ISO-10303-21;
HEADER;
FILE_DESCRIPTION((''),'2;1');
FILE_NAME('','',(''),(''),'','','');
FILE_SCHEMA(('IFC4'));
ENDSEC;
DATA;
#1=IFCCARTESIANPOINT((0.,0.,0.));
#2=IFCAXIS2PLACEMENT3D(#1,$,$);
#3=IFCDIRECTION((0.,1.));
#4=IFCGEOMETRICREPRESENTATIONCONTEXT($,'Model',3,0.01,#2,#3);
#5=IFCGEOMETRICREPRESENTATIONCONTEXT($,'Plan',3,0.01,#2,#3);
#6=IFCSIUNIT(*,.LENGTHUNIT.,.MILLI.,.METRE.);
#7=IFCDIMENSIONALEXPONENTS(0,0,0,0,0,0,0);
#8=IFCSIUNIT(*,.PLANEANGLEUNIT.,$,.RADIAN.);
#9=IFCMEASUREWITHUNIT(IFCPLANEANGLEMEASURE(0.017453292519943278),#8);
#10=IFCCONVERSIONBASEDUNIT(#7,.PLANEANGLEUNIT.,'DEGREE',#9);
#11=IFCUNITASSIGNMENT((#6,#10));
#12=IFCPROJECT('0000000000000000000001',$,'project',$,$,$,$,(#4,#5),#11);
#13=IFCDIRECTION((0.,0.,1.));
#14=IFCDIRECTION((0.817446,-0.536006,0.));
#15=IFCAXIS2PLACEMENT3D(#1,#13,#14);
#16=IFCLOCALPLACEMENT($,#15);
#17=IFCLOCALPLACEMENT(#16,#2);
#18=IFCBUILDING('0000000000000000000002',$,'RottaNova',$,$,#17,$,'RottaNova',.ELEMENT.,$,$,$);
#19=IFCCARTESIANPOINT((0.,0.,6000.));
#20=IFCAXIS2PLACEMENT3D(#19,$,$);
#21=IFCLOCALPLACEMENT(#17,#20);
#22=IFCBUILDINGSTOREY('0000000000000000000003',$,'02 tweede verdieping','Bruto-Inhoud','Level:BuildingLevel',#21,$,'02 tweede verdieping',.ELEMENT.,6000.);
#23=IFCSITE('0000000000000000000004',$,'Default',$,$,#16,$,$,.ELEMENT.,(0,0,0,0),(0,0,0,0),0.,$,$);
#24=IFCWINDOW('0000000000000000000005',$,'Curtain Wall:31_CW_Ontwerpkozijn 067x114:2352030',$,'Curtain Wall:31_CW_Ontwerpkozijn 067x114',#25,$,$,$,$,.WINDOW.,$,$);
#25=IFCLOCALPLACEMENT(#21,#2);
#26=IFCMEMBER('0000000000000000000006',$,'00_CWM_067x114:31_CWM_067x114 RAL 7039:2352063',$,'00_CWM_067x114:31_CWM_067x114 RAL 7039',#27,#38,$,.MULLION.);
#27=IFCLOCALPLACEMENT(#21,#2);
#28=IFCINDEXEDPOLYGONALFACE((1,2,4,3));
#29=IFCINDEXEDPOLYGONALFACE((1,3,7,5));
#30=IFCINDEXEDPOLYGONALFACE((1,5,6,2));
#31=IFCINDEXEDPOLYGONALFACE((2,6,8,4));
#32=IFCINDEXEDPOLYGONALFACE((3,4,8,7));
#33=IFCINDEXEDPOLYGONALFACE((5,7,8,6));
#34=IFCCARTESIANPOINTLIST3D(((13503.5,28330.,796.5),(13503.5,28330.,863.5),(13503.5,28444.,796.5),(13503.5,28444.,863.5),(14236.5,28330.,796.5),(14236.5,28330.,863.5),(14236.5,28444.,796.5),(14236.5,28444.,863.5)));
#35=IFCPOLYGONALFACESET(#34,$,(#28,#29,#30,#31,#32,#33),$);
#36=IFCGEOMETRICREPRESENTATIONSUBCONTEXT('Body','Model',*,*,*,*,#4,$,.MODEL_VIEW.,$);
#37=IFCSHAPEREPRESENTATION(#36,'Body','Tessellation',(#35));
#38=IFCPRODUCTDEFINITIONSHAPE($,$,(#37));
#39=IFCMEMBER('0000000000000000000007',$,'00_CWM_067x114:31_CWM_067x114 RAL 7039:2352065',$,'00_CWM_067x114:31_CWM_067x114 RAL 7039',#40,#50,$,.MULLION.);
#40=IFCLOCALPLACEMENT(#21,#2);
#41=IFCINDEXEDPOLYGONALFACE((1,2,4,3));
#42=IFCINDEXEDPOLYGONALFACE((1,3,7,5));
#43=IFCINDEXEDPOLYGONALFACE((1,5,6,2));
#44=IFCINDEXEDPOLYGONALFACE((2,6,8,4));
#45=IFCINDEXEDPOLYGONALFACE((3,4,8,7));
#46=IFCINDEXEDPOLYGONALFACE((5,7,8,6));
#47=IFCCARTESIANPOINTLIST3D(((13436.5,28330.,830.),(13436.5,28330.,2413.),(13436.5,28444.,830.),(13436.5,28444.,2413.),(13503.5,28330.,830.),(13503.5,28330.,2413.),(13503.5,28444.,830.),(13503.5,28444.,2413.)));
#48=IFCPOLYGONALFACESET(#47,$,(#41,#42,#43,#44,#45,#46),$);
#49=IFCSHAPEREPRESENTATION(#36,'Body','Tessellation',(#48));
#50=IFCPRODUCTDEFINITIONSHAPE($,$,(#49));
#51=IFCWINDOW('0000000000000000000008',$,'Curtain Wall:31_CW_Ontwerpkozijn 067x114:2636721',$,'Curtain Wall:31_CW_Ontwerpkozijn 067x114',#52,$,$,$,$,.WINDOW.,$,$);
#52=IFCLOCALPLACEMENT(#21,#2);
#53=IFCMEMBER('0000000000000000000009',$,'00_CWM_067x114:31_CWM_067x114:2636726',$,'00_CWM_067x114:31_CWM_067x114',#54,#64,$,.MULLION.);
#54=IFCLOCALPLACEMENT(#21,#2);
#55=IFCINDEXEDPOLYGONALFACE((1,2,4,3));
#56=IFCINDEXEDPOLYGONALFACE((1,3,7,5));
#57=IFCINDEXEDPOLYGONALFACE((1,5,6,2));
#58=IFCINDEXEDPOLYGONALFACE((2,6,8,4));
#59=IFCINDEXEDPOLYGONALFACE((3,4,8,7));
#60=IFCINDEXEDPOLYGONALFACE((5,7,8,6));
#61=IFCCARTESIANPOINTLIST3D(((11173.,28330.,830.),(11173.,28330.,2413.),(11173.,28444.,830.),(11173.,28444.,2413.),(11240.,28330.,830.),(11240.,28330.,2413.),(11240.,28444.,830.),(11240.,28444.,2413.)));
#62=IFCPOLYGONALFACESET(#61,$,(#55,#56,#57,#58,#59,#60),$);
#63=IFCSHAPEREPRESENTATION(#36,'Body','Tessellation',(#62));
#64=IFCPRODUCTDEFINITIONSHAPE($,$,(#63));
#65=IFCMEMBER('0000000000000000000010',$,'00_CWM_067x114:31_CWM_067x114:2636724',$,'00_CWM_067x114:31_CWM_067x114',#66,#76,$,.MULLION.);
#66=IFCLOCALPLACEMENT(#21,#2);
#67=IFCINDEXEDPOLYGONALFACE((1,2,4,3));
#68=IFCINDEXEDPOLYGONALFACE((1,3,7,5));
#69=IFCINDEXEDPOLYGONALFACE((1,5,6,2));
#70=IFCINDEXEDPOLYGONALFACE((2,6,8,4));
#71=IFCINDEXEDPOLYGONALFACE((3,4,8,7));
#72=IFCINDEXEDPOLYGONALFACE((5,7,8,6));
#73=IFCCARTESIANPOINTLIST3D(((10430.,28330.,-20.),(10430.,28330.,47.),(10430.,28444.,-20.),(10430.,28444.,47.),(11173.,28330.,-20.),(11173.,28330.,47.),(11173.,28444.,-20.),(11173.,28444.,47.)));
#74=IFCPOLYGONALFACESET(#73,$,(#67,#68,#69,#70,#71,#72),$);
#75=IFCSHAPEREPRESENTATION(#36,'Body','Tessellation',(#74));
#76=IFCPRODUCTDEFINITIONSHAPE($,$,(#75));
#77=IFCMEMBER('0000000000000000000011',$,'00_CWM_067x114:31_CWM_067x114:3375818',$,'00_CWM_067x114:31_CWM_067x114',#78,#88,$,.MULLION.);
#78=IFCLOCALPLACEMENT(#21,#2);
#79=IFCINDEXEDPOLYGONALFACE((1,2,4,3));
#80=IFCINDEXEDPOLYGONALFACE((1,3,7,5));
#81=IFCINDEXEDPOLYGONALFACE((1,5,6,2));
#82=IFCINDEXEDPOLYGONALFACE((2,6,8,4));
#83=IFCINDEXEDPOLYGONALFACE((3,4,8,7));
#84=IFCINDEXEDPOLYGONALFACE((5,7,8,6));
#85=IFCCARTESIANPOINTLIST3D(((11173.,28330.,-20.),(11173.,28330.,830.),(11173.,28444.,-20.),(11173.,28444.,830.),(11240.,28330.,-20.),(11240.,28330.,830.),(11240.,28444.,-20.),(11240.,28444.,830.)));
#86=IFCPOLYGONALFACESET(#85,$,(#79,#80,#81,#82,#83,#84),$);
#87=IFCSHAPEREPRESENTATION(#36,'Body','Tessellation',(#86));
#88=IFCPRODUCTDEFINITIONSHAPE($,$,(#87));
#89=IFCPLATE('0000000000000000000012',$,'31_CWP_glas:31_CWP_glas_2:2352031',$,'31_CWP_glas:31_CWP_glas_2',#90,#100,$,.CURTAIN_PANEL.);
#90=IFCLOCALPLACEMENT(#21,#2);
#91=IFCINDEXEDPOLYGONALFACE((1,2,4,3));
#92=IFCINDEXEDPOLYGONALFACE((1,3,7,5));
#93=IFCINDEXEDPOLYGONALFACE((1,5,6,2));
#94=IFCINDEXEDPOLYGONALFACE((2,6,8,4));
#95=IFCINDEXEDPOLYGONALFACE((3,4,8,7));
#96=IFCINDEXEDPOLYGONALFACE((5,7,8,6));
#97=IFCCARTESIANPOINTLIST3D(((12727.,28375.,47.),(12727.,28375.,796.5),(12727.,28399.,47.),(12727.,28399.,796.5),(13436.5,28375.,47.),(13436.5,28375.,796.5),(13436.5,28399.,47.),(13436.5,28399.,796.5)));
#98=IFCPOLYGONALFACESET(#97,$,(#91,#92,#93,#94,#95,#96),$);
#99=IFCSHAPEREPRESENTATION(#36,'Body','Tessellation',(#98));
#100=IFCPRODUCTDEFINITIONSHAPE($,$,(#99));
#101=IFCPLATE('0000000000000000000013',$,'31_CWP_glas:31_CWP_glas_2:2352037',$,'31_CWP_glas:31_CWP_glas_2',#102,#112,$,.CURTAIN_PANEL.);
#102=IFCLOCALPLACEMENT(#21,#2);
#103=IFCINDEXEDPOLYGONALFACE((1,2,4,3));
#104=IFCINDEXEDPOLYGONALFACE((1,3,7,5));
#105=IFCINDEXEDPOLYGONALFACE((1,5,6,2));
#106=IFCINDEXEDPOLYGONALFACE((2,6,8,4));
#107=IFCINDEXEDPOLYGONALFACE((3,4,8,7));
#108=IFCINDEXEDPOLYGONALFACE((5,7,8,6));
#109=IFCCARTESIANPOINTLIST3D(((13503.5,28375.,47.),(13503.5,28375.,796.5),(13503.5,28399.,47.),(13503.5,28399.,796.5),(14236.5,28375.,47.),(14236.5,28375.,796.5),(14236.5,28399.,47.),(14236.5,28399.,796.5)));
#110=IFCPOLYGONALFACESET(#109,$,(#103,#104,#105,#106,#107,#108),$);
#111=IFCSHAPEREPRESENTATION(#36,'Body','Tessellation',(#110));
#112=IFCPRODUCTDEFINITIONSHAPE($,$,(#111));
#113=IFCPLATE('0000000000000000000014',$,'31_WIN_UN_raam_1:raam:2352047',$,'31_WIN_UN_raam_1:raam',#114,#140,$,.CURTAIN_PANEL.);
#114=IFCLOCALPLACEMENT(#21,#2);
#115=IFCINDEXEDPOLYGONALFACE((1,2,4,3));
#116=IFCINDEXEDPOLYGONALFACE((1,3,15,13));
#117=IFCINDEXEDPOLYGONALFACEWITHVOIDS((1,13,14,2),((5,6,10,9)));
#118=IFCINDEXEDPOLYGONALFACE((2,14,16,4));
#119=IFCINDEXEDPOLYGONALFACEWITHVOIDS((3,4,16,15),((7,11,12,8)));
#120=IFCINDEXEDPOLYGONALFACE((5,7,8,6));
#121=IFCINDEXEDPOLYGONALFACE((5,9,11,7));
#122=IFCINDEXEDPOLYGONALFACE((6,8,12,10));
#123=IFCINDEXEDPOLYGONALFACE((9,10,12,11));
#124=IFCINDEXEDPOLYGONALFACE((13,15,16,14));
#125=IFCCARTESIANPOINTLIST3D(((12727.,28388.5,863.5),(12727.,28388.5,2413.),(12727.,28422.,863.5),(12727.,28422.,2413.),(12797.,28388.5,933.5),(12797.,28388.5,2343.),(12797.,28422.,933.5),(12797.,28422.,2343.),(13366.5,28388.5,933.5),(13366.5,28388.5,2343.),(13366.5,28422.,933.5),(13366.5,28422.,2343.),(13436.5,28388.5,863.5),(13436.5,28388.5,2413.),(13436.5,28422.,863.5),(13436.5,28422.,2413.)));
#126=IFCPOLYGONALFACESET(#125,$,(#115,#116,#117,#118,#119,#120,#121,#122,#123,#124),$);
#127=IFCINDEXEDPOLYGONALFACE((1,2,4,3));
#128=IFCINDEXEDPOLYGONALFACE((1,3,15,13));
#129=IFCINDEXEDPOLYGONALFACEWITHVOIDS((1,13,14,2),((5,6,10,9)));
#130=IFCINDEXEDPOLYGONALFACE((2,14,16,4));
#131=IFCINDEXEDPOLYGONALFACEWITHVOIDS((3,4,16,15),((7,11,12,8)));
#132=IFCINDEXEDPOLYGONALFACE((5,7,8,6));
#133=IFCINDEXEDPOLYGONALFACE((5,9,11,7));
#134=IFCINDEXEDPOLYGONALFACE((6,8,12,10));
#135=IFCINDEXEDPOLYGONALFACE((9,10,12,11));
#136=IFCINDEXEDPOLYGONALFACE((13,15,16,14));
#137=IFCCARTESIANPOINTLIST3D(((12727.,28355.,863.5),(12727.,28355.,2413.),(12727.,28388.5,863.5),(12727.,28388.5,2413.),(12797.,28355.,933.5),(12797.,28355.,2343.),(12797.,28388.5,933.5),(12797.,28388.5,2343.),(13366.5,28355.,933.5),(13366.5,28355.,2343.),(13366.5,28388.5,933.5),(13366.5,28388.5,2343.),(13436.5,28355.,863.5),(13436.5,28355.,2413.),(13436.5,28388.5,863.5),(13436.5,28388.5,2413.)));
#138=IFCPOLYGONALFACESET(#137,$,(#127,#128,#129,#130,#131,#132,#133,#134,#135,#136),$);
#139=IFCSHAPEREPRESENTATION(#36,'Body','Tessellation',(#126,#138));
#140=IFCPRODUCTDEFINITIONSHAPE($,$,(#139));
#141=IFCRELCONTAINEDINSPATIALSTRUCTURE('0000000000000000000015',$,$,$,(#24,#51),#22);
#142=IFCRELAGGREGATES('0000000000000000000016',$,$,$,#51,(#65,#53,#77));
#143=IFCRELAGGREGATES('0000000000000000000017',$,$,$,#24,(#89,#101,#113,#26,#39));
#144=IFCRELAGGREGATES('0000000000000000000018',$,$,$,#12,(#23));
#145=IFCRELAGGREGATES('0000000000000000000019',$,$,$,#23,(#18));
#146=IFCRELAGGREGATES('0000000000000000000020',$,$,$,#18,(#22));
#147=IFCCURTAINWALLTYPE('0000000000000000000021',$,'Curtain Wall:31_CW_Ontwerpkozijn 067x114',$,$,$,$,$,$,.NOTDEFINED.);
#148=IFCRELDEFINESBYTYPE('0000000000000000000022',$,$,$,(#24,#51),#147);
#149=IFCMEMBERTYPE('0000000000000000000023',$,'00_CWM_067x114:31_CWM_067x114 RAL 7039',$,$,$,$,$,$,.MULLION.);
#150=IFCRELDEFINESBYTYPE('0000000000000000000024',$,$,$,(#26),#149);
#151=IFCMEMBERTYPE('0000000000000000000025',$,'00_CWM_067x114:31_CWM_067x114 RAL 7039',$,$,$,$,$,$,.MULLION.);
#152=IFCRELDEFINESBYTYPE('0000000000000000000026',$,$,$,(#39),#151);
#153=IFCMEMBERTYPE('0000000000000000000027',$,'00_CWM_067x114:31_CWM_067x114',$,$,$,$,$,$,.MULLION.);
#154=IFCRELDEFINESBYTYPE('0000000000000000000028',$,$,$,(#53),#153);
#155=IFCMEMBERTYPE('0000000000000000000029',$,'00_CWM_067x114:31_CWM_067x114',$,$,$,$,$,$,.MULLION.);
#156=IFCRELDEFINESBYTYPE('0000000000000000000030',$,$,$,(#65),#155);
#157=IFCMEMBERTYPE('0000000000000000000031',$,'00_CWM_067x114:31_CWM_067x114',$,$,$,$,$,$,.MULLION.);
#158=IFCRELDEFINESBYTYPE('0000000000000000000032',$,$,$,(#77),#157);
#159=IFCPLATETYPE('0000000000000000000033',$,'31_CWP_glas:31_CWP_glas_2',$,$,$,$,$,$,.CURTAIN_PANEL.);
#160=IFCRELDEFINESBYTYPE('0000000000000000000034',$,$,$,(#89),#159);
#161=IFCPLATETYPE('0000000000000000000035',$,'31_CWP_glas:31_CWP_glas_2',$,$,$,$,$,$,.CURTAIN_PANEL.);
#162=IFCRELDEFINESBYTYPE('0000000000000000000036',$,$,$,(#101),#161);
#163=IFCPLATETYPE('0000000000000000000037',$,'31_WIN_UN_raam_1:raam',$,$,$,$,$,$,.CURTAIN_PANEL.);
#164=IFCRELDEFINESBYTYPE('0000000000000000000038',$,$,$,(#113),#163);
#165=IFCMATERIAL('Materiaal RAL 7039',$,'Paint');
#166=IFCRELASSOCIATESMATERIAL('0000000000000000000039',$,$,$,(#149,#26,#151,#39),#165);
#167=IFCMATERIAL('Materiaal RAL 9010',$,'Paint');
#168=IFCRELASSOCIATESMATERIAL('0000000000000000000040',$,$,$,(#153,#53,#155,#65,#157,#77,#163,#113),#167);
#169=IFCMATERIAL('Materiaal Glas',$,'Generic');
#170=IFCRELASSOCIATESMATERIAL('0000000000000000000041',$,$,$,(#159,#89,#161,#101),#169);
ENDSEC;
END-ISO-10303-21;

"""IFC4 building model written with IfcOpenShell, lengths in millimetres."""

from ifc_helpers import new_model, entity, si_unit, converted_unit, direction, frame, origin, place, context, subcontext, project, spatial, indexed_curve, outline, extrude, source, transform, mapped, material, type_object, type_shapes, element, aggregate, save


model = new_model("IFC4")

# Units and contexts
model_context = context("Model", 3, precision=0.01, world=origin(), true_north=direction((0.0, 1.0)))
plan_context = context("Plan", 3, precision=0.01, world=origin(), true_north=direction((0.0, 1.0)))
body_context = subcontext(model_context, "Body", "Model", "MODEL_VIEW")
ifc_project = project(units=[si_unit("LENGTHUNIT", "METRE", prefix="MILLI"), converted_unit("PLANEANGLEUNIT", "DEGREE", entity("IfcPlaneAngleMeasure", 0.017453292519943278), si_unit("PLANEANGLEUNIT", "RADIAN"), dimensions=[0, 0, 0, 0, 0, 0, 0])], contexts=[model_context, plan_context])

# Site, building, storey
site_placement = place(None, frame((0.0, 0.0, 0.0), z_axis=(0.0, 0.0, 1.0), x_axis=(0.817446, -0.536006, 0.0)))
site = spatial("IfcSite", under=ifc_project, at=site_placement, Name="Default", CompositionType="ELEMENT", RefLatitude=(0, 0, 0, 0), RefLongitude=(0, 0, 0, 0), RefElevation=0.0)
building_placement = place(site_placement, origin())
building = spatial("IfcBuilding", under=site, at=building_placement, Name="RottaNova", LongName="RottaNova", CompositionType="ELEMENT")
storey_placement = place(building_placement, frame((0.0, 0.0, 6000.0)))
storey = spatial("IfcBuildingStorey", under=building, at=storey_placement, Name="02 tweede verdieping", Description="Bruto-Inhoud", ObjectType="Level:BuildingLevel", LongName="02 tweede verdieping", CompositionType="ELEMENT", Elevation=6000.0)

# Windows, members
curtain_wall_type = type_object("IfcCurtainWallType", Name="Curtain Wall:31_CW_Ontwerpkozijn 067x114", PredefinedType="NOTDEFINED")
window_1_placement = place(storey_placement, frame((0.0, 0.0, -6000.0)))
window_1 = element("IfcWindow", 1, at=window_1_placement, inside=storey, type_object=curtain_wall_type, Name="Curtain Wall:31_CW_Ontwerpkozijn 067x114:2352030", ObjectType="Curtain Wall:31_CW_Ontwerpkozijn 067x114", PredefinedType="WINDOW")
ifc_material_1 = material(Name="Materiaal RAL 7039", Category="Paint")
member_type_1 = type_object("IfcMemberType", Name="00_CWM_067x114:31_CWM_067x114 RAL 7039", PredefinedType="MULLION", material=ifc_material_1)
shared_shape_1 = source(origin(), body_context, "Body", "SweptSolid", [
    extrude(outline(indexed_curve([(-33.5, -57.0), (33.5, -57.0), (33.5, 57.0), (-33.5, 57.0), (-33.5, -57.0)], self_intersect=False)), frame((0.0, -57.0, -733.0), z_axis=(0.0, 0.0, 1.0), x_axis=(-1.0, 0.0, 0.0)), (0.0, 0.0, 1.0), 733.0),
])
type_shapes(member_type_1, [shared_shape_1])
member_1_placement = place(window_1_placement, frame((14236.5, 28330.0, 6830.0), z_axis=(1.0, 0.0, 0.0), x_axis=(0.0, 0.0, 1.0)))
member_1 = element("IfcMember", 2, at=member_1_placement, type_object=member_type_1, material=ifc_material_1, Name="00_CWM_067x114:31_CWM_067x114 RAL 7039:2352063", ObjectType="00_CWM_067x114:31_CWM_067x114 RAL 7039", PredefinedType="MULLION", context=body_context, shape_type="MappedRepresentation", body=[
    mapped(shared_shape_1, transform((0.0, 0.0, 0.0), scale=1.0)),
])
member_type_2 = type_object("IfcMemberType", Name="00_CWM_067x114:31_CWM_067x114 RAL 7039", PredefinedType="MULLION", material=ifc_material_1)
shared_shape_2 = source(origin(), body_context, "Body", "SweptSolid", [
    extrude(outline(indexed_curve([(-33.5, -57.0), (33.5, -57.0), (33.5, 57.0), (-33.5, 57.0), (-33.5, -57.0)], self_intersect=False)), frame((0.0, -57.0, -1583.0), z_axis=(0.0, 0.0, 1.0), x_axis=(-1.0, 0.0, 0.0)), (0.0, 0.0, 1.0), 1583.0),
])
type_shapes(member_type_2, [shared_shape_2])
member_2_placement = place(window_1_placement, frame((13470.0, 28330.0, 6830.0), z_axis=(0.0, 0.0, -1.0), x_axis=(1.0, 0.0, 0.0)))
member_2 = element("IfcMember", 3, at=member_2_placement, type_object=member_type_2, material=ifc_material_1, Name="00_CWM_067x114:31_CWM_067x114 RAL 7039:2352065", ObjectType="00_CWM_067x114:31_CWM_067x114 RAL 7039", PredefinedType="MULLION", context=body_context, shape_type="MappedRepresentation", body=[
    mapped(shared_shape_2, transform((0.0, 0.0, 0.0), scale=1.0)),
])
window_2_placement = place(storey_placement, frame((0.0, 0.0, -6000.0)))
window_2 = element("IfcWindow", 4, at=window_2_placement, inside=storey, type_object=curtain_wall_type, Name="Curtain Wall:31_CW_Ontwerpkozijn 067x114:2636721", ObjectType="Curtain Wall:31_CW_Ontwerpkozijn 067x114", PredefinedType="WINDOW")
ifc_material_2 = material(Name="Materiaal RAL 9010", Category="Paint")
member_type_3 = type_object("IfcMemberType", Name="00_CWM_067x114:31_CWM_067x114", PredefinedType="MULLION", material=ifc_material_2)
shared_shape_3 = source(origin(), body_context, "Body", "SweptSolid", [
    extrude(outline(indexed_curve([(-33.5, -57.0), (33.5, -57.0), (33.5, 57.0), (-33.5, 57.0), (-33.5, -57.0)], self_intersect=False)), frame((-33.5, 57.0, -1583.0), z_axis=(0.0, 0.0, 1.0), x_axis=(-1.0, 0.0, 0.0)), (0.0, 0.0, 1.0), 1583.0),
])
type_shapes(member_type_3, [shared_shape_3])
member_3_placement = place(window_2_placement, frame((11240.0, 28330.0, 8413.0)))
member_3 = element("IfcMember", 5, at=member_3_placement, type_object=member_type_3, material=ifc_material_2, Name="00_CWM_067x114:31_CWM_067x114:2636726", ObjectType="00_CWM_067x114:31_CWM_067x114", PredefinedType="MULLION", context=body_context, shape_type="MappedRepresentation", body=[
    mapped(shared_shape_3, transform((0.0, 0.0, 0.0), scale=1.0)),
])
member_type_4 = type_object("IfcMemberType", Name="00_CWM_067x114:31_CWM_067x114", PredefinedType="MULLION", material=ifc_material_2)
shared_shape_4 = source(origin(), body_context, "Body", "SweptSolid", [
    extrude(outline(indexed_curve([(-33.5, -57.0), (33.5, -57.0), (33.5, 57.0), (-33.5, 57.0), (-33.5, -57.0)], self_intersect=False)), frame((-33.5, 57.0, -743.0), z_axis=(0.0, 0.0, 1.0), x_axis=(-1.0, 0.0, 0.0)), (0.0, 0.0, 1.0), 743.0),
])
type_shapes(member_type_4, [shared_shape_4])
member_4_placement = place(window_2_placement, frame((11173.0, 28330.0, 5980.0), z_axis=(1.0, 0.0, 0.0), x_axis=(0.0, 0.0, -1.0)))
member_4 = element("IfcMember", 6, at=member_4_placement, type_object=member_type_4, material=ifc_material_2, Name="00_CWM_067x114:31_CWM_067x114:2636724", ObjectType="00_CWM_067x114:31_CWM_067x114", PredefinedType="MULLION", context=body_context, shape_type="MappedRepresentation", body=[
    mapped(shared_shape_4, transform((0.0, 0.0, 0.0), scale=1.0)),
])
member_type_5 = type_object("IfcMemberType", Name="00_CWM_067x114:31_CWM_067x114", PredefinedType="MULLION", material=ifc_material_2)
shared_shape_5 = source(origin(), body_context, "Body", "SweptSolid", [
    extrude(outline(indexed_curve([(-33.5, -57.0), (33.5, -57.0), (33.5, 57.0), (-33.5, 57.0), (-33.5, -57.0)], self_intersect=False)), frame((-33.5, 57.0, -850.0), z_axis=(0.0, 0.0, 1.0), x_axis=(-1.0, 0.0, 0.0)), (0.0, 0.0, 1.0), 850.0),
])
type_shapes(member_type_5, [shared_shape_5])
member_5_placement = place(window_2_placement, frame((11240.0, 28330.0, 6830.0)))
member_5 = element("IfcMember", 7, at=member_5_placement, type_object=member_type_5, material=ifc_material_2, Name="00_CWM_067x114:31_CWM_067x114:3375818", ObjectType="00_CWM_067x114:31_CWM_067x114", PredefinedType="MULLION", context=body_context, shape_type="MappedRepresentation", body=[
    mapped(shared_shape_5, transform((0.0, 0.0, 0.0), scale=1.0)),
])
aggregate(window_2, [member_4, member_3, member_5])

# Plates
ifc_material_3 = material(Name="Materiaal Glas", Category="Generic")
plate_type_1 = type_object("IfcPlateType", Name="31_CWP_glas:31_CWP_glas_2", PredefinedType="CURTAIN_PANEL", material=ifc_material_3)
shared_shape_6 = source(origin(), body_context, "Body", "SweptSolid", [
    extrude(outline(indexed_curve([(-12.0, -354.8), (12.0, -354.8), (12.0, 354.8), (-12.0, 354.8), (-12.0, -354.8)], self_intersect=False)), frame((0.0, 57.0, 0.0), z_axis=(0.0, 0.0, 1.0), x_axis=(0.0, 1.0, 0.0)), (0.0, 0.0, 1.0), 749.5),
])
type_shapes(plate_type_1, [shared_shape_6])
plate_1_placement = place(window_1_placement, frame((13081.8, 28330.0, 6047.0)))
plate_1 = element("IfcPlate", 8, at=plate_1_placement, type_object=plate_type_1, material=ifc_material_3, Name="31_CWP_glas:31_CWP_glas_2:2352031", ObjectType="31_CWP_glas:31_CWP_glas_2", PredefinedType="CURTAIN_PANEL", context=body_context, shape_type="MappedRepresentation", body=[
    mapped(shared_shape_6, transform((0.0, 0.0, 0.0), scale=1.0)),
])
plate_type_2 = type_object("IfcPlateType", Name="31_CWP_glas:31_CWP_glas_2", PredefinedType="CURTAIN_PANEL", material=ifc_material_3)
shared_shape_7 = source(origin(), body_context, "Body", "SweptSolid", [
    extrude(outline(indexed_curve([(-12.0, -366.5), (12.0, -366.5), (12.0, 366.5), (-12.0, 366.5), (-12.0, -366.5)], self_intersect=False)), frame((0.0, 57.0, 0.0), z_axis=(0.0, 0.0, 1.0), x_axis=(0.0, 1.0, 0.0)), (0.0, 0.0, 1.0), 749.5),
])
type_shapes(plate_type_2, [shared_shape_7])
plate_2_placement = place(window_1_placement, frame((13870.0, 28330.0, 6047.0)))
plate_2 = element("IfcPlate", 9, at=plate_2_placement, type_object=plate_type_2, material=ifc_material_3, Name="31_CWP_glas:31_CWP_glas_2:2352037", ObjectType="31_CWP_glas:31_CWP_glas_2", PredefinedType="CURTAIN_PANEL", context=body_context, shape_type="MappedRepresentation", body=[
    mapped(shared_shape_7, transform((0.0, 0.0, 0.0), scale=1.0)),
])
plate_type_3 = type_object("IfcPlateType", Name="31_WIN_UN_raam_1:raam", PredefinedType="CURTAIN_PANEL", material=ifc_material_2)
shared_shape_8 = source(origin(), body_context, "Body", "SweptSolid", [
    extrude(outline(indexed_curve([(-354.7, -774.7), (354.7, -774.7), (354.7, 774.7), (-354.7, 774.7), (-354.7, -774.7)], self_intersect=False), holes=[indexed_curve([(-284.7, 704.7), (284.7, 704.7), (284.7, -704.8), (-284.7, -704.8), (-284.7, 704.7)], self_intersect=False)]), frame((0.0, 58.5, 774.8), z_axis=(0.0, 1.0, 0.0), x_axis=(1.0, 0.0, 0.0)), (0.0, 0.0, 1.0), 33.5),
    extrude(outline(indexed_curve([(-354.7, -774.7), (354.7, -774.7), (354.7, 774.7), (-354.7, 774.7), (-354.7, -774.7)], self_intersect=False), holes=[indexed_curve([(-284.7, 704.7), (284.7, 704.7), (284.7, -704.8), (-284.7, -704.8), (-284.7, 704.7)], self_intersect=False)]), frame((0.0, 25.0, 774.8), z_axis=(0.0, 1.0, 0.0), x_axis=(1.0, 0.0, 0.0)), (0.0, 0.0, 1.0), 33.5),
])
type_shapes(plate_type_3, [shared_shape_8])
plate_3_placement = place(window_1_placement, frame((13081.8, 28330.0, 6863.5)))
plate_3 = element("IfcPlate", 10, at=plate_3_placement, type_object=plate_type_3, material=ifc_material_2, Name="31_WIN_UN_raam_1:raam:2352047", ObjectType="31_WIN_UN_raam_1:raam", PredefinedType="CURTAIN_PANEL", context=body_context, shape_type="MappedRepresentation", body=[
    mapped(shared_shape_8, transform((0.0, 0.0, 0.0), scale=1.0)),
])
aggregate(window_1, [plate_1, plate_2, plate_3, member_1, member_2])

save(model, "model.ifc")
